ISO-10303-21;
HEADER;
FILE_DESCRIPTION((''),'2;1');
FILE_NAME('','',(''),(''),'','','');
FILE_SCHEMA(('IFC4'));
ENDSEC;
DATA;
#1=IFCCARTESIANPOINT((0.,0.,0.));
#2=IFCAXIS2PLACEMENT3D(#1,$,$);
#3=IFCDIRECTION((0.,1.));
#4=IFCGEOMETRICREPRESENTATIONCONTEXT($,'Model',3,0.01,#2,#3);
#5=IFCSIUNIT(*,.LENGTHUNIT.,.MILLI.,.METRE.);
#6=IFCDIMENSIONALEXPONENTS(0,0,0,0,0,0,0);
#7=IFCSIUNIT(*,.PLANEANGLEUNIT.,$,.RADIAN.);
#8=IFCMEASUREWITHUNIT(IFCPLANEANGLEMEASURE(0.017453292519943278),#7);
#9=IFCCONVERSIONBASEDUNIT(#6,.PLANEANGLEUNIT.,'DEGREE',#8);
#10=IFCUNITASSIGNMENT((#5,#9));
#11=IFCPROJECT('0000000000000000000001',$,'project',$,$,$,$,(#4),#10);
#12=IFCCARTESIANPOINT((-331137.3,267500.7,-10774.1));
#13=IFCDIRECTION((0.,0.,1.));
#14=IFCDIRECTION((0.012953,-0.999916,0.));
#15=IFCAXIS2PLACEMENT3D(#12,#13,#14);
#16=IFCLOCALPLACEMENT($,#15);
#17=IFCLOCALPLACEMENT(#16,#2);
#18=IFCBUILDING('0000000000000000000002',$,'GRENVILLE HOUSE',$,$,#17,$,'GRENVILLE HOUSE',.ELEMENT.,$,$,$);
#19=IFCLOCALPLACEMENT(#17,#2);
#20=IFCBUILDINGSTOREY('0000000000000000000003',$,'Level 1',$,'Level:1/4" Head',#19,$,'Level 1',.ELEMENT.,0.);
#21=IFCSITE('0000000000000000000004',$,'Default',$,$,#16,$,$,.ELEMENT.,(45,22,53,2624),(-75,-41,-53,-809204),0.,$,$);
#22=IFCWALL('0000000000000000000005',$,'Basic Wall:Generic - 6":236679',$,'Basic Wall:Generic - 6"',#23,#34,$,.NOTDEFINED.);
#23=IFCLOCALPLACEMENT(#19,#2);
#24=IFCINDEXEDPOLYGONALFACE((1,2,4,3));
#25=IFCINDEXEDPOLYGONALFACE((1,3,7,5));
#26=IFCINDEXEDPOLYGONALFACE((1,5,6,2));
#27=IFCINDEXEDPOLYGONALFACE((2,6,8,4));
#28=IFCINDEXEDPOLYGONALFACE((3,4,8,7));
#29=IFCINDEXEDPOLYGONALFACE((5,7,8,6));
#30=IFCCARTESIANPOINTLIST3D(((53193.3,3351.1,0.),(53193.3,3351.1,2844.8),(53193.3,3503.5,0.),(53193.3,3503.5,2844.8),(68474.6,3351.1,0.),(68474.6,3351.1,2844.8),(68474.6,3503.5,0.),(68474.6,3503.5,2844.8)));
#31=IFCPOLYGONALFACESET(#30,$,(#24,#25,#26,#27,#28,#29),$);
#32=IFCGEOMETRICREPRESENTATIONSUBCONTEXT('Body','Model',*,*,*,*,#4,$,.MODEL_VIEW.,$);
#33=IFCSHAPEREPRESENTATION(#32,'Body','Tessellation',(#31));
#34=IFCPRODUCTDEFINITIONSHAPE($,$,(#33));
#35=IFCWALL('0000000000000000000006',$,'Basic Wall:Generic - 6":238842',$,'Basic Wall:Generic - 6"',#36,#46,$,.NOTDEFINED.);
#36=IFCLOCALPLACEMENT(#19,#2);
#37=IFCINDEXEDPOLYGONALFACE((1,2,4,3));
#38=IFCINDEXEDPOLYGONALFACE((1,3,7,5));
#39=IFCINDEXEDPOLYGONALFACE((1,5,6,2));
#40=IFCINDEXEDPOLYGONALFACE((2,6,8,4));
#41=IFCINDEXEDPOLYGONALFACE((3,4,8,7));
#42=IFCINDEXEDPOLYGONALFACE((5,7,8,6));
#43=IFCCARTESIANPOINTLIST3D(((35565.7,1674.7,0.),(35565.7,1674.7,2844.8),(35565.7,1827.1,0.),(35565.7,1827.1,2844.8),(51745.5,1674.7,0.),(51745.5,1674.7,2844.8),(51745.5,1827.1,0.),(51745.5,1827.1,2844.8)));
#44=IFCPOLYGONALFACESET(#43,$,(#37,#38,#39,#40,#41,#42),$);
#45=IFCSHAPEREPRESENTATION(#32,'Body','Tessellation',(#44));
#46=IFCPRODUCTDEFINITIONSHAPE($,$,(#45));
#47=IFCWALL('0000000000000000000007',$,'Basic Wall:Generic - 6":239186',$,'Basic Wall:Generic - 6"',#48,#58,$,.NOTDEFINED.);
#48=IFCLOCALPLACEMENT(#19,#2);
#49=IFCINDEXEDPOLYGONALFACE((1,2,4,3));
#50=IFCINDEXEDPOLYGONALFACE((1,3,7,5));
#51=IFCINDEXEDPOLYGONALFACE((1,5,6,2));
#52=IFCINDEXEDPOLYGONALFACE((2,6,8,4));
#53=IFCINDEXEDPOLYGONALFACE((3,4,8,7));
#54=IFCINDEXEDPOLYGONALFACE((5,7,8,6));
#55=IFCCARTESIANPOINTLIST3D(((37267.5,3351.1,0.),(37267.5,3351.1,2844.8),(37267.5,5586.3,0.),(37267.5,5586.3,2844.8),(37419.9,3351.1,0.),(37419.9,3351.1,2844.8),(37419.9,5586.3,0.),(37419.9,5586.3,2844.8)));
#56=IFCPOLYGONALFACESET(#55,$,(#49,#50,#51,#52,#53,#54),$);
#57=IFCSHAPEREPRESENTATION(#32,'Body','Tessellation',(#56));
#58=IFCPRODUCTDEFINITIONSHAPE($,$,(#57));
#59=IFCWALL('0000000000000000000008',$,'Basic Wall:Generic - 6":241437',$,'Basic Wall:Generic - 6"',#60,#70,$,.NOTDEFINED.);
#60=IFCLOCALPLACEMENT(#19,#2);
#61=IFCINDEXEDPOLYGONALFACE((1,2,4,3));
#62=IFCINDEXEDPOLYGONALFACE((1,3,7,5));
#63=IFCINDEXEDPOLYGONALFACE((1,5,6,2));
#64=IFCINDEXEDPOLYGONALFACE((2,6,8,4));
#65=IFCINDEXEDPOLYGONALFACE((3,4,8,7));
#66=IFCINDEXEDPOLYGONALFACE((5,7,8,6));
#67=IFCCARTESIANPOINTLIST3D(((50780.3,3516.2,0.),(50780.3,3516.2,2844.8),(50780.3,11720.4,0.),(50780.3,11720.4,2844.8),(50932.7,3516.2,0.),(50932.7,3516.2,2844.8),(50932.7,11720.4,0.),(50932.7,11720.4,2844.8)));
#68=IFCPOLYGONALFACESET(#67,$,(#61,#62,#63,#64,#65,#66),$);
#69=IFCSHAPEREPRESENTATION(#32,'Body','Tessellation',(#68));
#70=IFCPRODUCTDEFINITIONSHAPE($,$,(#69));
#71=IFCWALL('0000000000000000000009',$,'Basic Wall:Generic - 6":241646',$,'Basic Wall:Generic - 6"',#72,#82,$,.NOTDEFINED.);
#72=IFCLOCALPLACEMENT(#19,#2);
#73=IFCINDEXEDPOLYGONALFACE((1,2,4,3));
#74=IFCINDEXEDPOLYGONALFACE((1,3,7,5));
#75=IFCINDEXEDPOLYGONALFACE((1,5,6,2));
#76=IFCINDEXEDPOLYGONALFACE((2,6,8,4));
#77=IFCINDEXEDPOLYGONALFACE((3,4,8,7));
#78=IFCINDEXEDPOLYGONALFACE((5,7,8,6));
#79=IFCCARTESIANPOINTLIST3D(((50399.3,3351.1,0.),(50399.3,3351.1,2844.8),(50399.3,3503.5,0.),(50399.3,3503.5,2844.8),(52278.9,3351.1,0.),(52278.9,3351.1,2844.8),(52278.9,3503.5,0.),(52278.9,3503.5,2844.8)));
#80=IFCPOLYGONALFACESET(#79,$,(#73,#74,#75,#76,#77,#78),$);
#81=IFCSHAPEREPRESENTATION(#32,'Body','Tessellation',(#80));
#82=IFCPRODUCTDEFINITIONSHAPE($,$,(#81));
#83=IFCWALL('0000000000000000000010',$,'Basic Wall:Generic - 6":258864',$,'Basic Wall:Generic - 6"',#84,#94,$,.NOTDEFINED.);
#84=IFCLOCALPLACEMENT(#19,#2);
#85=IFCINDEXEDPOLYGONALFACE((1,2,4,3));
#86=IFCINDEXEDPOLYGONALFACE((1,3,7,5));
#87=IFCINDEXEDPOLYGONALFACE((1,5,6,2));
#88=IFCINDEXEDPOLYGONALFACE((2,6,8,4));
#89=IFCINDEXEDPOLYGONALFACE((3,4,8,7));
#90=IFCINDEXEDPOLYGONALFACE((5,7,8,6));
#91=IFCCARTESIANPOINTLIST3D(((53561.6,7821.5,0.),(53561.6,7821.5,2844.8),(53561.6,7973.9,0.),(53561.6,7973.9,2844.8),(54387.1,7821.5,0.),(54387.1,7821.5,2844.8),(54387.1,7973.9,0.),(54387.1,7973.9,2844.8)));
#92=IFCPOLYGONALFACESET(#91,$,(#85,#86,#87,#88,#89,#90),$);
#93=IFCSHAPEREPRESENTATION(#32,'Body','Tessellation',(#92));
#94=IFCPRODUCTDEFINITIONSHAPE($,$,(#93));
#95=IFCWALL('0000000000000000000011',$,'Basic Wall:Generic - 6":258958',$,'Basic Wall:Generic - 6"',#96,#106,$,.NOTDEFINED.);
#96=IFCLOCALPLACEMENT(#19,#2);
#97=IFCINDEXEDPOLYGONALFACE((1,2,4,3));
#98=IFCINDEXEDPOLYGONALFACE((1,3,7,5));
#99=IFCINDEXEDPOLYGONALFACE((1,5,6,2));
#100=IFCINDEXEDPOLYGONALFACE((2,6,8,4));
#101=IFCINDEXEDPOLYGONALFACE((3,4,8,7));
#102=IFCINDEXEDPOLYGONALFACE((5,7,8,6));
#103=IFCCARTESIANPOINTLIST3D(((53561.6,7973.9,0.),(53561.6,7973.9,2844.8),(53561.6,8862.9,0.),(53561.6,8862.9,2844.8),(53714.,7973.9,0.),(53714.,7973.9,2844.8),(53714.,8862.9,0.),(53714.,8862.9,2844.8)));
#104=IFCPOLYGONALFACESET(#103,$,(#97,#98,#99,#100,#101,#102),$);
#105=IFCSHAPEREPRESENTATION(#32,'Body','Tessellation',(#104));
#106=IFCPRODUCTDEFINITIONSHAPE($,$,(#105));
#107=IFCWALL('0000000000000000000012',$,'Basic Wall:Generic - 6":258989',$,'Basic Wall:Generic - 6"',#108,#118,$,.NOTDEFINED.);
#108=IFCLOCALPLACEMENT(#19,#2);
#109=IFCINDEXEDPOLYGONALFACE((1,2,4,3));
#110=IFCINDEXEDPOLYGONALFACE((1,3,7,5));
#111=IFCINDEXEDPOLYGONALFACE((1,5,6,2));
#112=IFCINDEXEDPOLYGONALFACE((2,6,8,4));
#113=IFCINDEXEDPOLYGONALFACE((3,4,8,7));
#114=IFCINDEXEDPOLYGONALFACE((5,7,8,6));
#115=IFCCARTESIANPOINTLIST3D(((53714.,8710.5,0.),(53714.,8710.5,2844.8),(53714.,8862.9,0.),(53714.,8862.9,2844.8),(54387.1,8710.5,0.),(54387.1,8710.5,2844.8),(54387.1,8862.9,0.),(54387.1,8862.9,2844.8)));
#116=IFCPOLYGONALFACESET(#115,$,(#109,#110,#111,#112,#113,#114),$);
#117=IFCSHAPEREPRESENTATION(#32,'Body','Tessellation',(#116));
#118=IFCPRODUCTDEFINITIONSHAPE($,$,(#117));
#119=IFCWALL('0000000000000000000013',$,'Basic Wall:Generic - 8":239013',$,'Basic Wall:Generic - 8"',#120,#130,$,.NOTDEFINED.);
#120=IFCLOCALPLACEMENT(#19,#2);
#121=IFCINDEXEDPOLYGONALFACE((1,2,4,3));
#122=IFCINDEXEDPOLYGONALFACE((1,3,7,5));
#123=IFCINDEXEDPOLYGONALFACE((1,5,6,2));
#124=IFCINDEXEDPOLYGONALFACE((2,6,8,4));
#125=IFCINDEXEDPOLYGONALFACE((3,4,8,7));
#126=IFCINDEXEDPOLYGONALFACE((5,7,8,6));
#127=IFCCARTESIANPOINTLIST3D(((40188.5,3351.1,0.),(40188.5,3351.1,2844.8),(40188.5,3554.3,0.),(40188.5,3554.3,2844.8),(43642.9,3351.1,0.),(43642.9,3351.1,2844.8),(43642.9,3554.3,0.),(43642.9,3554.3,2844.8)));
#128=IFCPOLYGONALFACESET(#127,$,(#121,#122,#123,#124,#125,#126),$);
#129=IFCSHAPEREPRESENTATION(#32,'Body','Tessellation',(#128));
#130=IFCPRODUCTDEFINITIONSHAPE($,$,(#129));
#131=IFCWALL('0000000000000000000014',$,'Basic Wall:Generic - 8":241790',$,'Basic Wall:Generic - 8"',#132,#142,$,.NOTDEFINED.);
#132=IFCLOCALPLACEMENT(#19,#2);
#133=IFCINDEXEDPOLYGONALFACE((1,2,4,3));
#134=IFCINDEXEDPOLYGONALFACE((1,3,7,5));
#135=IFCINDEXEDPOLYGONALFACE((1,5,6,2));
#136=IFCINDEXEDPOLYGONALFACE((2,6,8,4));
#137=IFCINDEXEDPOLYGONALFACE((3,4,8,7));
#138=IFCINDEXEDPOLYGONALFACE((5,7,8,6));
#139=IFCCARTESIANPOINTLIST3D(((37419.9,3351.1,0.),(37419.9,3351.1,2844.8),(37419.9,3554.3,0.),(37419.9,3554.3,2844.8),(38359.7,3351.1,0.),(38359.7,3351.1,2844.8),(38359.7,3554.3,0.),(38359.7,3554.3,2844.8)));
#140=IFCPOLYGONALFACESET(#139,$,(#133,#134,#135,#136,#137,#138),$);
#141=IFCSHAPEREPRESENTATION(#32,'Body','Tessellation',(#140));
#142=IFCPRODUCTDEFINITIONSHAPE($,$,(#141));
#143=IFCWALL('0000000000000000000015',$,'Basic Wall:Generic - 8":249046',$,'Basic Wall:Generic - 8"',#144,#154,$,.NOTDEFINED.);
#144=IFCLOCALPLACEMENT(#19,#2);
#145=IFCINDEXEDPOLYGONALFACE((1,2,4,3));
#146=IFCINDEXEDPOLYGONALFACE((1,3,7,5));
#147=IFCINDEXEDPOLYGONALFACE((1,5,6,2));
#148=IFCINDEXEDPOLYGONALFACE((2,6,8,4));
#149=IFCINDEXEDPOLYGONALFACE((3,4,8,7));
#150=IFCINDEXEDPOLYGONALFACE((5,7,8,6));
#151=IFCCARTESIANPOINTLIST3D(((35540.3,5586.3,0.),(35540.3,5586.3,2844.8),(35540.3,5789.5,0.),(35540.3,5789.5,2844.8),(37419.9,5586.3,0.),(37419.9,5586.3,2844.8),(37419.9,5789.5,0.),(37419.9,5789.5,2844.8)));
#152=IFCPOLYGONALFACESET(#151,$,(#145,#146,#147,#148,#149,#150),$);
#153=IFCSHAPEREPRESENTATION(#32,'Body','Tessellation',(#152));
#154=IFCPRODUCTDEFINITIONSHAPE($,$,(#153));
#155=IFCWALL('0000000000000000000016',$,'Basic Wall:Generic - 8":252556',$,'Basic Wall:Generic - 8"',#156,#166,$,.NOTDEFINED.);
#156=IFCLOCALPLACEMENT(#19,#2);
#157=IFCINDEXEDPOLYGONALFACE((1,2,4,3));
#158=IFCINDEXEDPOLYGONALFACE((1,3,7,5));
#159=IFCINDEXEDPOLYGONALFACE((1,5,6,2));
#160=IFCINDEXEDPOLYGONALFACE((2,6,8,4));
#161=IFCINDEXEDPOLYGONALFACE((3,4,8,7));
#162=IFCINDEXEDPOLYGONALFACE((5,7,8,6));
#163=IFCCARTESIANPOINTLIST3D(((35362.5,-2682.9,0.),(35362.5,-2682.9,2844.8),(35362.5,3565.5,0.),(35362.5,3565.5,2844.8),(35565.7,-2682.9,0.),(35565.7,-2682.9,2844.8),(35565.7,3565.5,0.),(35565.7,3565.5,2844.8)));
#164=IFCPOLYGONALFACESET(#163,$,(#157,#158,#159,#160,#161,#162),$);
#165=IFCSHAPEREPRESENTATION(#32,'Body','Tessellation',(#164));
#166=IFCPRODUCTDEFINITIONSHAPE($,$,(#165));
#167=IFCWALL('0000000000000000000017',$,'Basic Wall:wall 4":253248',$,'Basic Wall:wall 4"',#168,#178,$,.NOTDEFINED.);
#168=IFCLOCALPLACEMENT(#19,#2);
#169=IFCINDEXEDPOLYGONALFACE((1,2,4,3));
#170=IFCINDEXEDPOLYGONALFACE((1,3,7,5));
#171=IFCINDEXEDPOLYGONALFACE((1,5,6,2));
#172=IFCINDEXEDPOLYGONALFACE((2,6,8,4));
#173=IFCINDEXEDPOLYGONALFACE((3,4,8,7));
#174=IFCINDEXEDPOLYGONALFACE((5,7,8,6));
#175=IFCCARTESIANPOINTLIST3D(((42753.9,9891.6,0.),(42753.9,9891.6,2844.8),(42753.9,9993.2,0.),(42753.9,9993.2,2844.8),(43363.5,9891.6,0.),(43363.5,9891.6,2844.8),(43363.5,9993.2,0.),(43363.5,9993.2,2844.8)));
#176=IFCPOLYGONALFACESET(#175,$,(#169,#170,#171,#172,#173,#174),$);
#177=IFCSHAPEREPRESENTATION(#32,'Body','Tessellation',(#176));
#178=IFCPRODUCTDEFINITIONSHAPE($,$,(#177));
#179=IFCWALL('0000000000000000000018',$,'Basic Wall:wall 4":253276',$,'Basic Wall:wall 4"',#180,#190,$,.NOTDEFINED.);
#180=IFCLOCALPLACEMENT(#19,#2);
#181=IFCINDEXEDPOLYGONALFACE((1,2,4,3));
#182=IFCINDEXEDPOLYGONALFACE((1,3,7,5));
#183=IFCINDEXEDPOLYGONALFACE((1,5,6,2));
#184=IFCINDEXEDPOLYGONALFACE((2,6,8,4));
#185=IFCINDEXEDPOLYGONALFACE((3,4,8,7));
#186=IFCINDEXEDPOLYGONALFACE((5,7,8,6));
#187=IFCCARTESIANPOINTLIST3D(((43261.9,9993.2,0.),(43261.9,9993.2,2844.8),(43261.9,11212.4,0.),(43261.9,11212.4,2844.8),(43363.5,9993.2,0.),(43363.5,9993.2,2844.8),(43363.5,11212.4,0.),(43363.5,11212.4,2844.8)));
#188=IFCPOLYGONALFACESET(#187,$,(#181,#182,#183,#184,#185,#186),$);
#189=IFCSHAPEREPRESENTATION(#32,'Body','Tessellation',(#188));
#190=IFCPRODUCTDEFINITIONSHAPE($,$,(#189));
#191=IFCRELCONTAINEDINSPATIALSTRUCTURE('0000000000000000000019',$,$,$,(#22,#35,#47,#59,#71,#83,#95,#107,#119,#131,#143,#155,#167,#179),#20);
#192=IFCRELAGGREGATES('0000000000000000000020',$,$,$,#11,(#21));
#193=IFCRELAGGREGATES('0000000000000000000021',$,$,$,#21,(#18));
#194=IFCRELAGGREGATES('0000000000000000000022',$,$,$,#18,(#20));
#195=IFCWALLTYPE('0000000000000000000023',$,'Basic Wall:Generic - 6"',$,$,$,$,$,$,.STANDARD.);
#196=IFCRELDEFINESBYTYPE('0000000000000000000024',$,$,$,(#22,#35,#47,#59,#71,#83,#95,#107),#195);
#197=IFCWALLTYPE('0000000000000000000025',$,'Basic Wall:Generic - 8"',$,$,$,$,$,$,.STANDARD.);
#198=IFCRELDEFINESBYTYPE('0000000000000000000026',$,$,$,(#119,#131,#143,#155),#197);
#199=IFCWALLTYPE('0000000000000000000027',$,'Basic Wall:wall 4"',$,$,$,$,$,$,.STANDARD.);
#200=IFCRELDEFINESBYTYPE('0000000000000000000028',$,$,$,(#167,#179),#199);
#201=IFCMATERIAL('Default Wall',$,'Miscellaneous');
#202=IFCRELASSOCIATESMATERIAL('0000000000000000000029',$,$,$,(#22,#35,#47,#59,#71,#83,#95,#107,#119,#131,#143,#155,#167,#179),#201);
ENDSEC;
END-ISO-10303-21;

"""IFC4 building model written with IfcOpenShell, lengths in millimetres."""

from ifc_helpers import new_model, entity, si_unit, converted_unit, direction, frame, origin, place, context, subcontext, project, spatial, indexed_curve, outline, extrude, material, type_object, element, save


model = new_model("IFC4")

# Units and contexts
model_context = context("Model", 3, precision=0.01, world=origin(), true_north=direction((0.0, 1.0)))
body_context = subcontext(model_context, "Body", "Model", "MODEL_VIEW")
ifc_project = project(units=[si_unit("LENGTHUNIT", "METRE", prefix="MILLI"), converted_unit("PLANEANGLEUNIT", "DEGREE", entity("IfcPlaneAngleMeasure", 0.017453292519943278), si_unit("PLANEANGLEUNIT", "RADIAN"), dimensions=[0, 0, 0, 0, 0, 0, 0])], contexts=[model_context])

# Site, building, storey
site_placement = place(None, frame((-331137.3, 267500.7, -10774.1), z_axis=(0.0, 0.0, 1.0), x_axis=(0.012953, -0.999916, 0.0)))
site = spatial("IfcSite", under=ifc_project, at=site_placement, Name="Default", CompositionType="ELEMENT", RefLatitude=(45, 22, 53, 2624), RefLongitude=(-75, -41, -53, -809204), RefElevation=0.0)
building_placement = place(site_placement, origin())
building = spatial("IfcBuilding", under=site, at=building_placement, Name="GRENVILLE HOUSE", LongName="GRENVILLE HOUSE", CompositionType="ELEMENT")
storey_placement = place(building_placement, origin())
storey = spatial("IfcBuildingStorey", under=building, at=storey_placement, Name="Level 1", ObjectType="Level:1/4\" Head", LongName="Level 1", CompositionType="ELEMENT", Elevation=0.0)

# Walls
ifc_material_1 = material(Name="Default Wall", Category="Miscellaneous")
wall_type_1 = type_object("IfcWallType", Name="Basic Wall:Generic - 6\"", PredefinedType="STANDARD")
wall_1_placement = place(storey_placement, frame((53193.3, 3427.3, 0.0)))
element("IfcWall", 1, at=wall_1_placement, inside=storey, type_object=wall_type_1, material=ifc_material_1, Name="Basic Wall:Generic - 6\":236679", ObjectType="Basic Wall:Generic - 6\"", PredefinedType="NOTDEFINED", context=body_context, shape_type="SweptSolid", body=[
    extrude(outline(indexed_curve([(15281.3, 76.2), (0.0, 76.2), (0.0, -76.2), (15281.3, -76.2), (15281.3, 76.2)], self_intersect=False)), origin(), (0.0, 0.0, 1.0), 2844.8),
])
wall_2_placement = place(storey_placement, frame((51745.5, 1750.9, 0.0), z_axis=(0.0, 0.0, 1.0), x_axis=(-1.0, 0.0, 0.0)))
element("IfcWall", 2, at=wall_2_placement, inside=storey, type_object=wall_type_1, material=ifc_material_1, Name="Basic Wall:Generic - 6\":238842", ObjectType="Basic Wall:Generic - 6\"", PredefinedType="NOTDEFINED", context=body_context, shape_type="SweptSolid", body=[
    extrude(outline(indexed_curve([(16179.8, 76.2), (0.0, 76.2), (0.0, -76.2), (16179.8, -76.2), (16179.8, 76.2)], self_intersect=False)), origin(), (0.0, 0.0, 1.0), 2844.8),
])
wall_3_placement = place(storey_placement, frame((37343.7, 3351.1, 0.0), z_axis=(0.0, 0.0, 1.0), x_axis=(0.0, 1.0, 0.0)))
element("IfcWall", 3, at=wall_3_placement, inside=storey, type_object=wall_type_1, material=ifc_material_1, Name="Basic Wall:Generic - 6\":239186", ObjectType="Basic Wall:Generic - 6\"", PredefinedType="NOTDEFINED", context=body_context, shape_type="SweptSolid", body=[
    extrude(outline(indexed_curve([(2235.2, 76.2), (0.0, 76.2), (0.0, -76.2), (2235.2, -76.2), (2235.2, 76.2)], self_intersect=False)), origin(), (0.0, 0.0, 1.0), 2844.8),
])
wall_4_placement = place(storey_placement, frame((50856.5, 3516.2, 0.0), z_axis=(0.0, 0.0, 1.0), x_axis=(0.0, 1.0, 0.0)))
element("IfcWall", 4, at=wall_4_placement, inside=storey, type_object=wall_type_1, material=ifc_material_1, Name="Basic Wall:Generic - 6\":241437", ObjectType="Basic Wall:Generic - 6\"", PredefinedType="NOTDEFINED", context=body_context, shape_type="SweptSolid", body=[
    extrude(outline(indexed_curve([(8204.2, 76.2), (0.0, 76.2), (0.0, -76.2), (8204.2, -76.2), (8204.2, 76.2)], self_intersect=False)), origin(), (0.0, 0.0, 1.0), 2844.8),
])
wall_5_placement = place(storey_placement, frame((52278.9, 3427.3, 0.0), z_axis=(0.0, 0.0, 1.0), x_axis=(-1.0, 0.0, 0.0)))
element("IfcWall", 5, at=wall_5_placement, inside=storey, type_object=wall_type_1, material=ifc_material_1, Name="Basic Wall:Generic - 6\":241646", ObjectType="Basic Wall:Generic - 6\"", PredefinedType="NOTDEFINED", context=body_context, shape_type="SweptSolid", body=[
    extrude(outline(indexed_curve([(1879.6, 76.2), (0.0, 76.2), (0.0, -76.2), (1879.6, -76.2), (1879.6, 76.2)], self_intersect=False)), origin(), (0.0, 0.0, 1.0), 2844.8),
])
wall_6_placement = place(storey_placement, frame((53561.6, 7897.7, 0.0)))
element("IfcWall", 6, at=wall_6_placement, inside=storey, type_object=wall_type_1, material=ifc_material_1, Name="Basic Wall:Generic - 6\":258864", ObjectType="Basic Wall:Generic - 6\"", PredefinedType="NOTDEFINED", context=body_context, shape_type="SweptSolid", body=[
    extrude(outline(indexed_curve([(825.5, 76.2), (0.0, 76.2), (0.0, -76.2), (825.5, -76.2), (825.5, 76.2)], self_intersect=False)), origin(), (0.0, 0.0, 1.0), 2844.8),
])
wall_7_placement = place(storey_placement, frame((53637.8, 7973.9, 0.0), z_axis=(0.0, 0.0, 1.0), x_axis=(0.0, 1.0, 0.0)))
element("IfcWall", 7, at=wall_7_placement, inside=storey, type_object=wall_type_1, material=ifc_material_1, Name="Basic Wall:Generic - 6\":258958", ObjectType="Basic Wall:Generic - 6\"", PredefinedType="NOTDEFINED", context=body_context, shape_type="SweptSolid", body=[
    extrude(outline(indexed_curve([(889.0, 76.2), (0.0, 76.2), (0.0, -76.2), (889.0, -76.2), (889.0, 76.2)], self_intersect=False)), origin(), (0.0, 0.0, 1.0), 2844.8),
])
wall_8_placement = place(storey_placement, frame((53714.0, 8786.7, 0.0)))
element("IfcWall", 8, at=wall_8_placement, inside=storey, type_object=wall_type_1, material=ifc_material_1, Name="Basic Wall:Generic - 6\":258989", ObjectType="Basic Wall:Generic - 6\"", PredefinedType="NOTDEFINED", context=body_context, shape_type="SweptSolid", body=[
    extrude(outline(indexed_curve([(673.1, 76.2), (0.0, 76.2), (0.0, -76.2), (673.1, -76.2), (673.1, 76.2)], self_intersect=False)), origin(), (0.0, 0.0, 1.0), 2844.8),
])
wall_type_2 = type_object("IfcWallType", Name="Basic Wall:Generic - 8\"", PredefinedType="STANDARD")
wall_9_placement = place(storey_placement, frame((43642.9, 3452.7, 0.0), z_axis=(0.0, 0.0, 1.0), x_axis=(-1.0, 0.0, 0.0)))
element("IfcWall", 9, at=wall_9_placement, inside=storey, type_object=wall_type_2, material=ifc_material_1, Name="Basic Wall:Generic - 8\":239013", ObjectType="Basic Wall:Generic - 8\"", PredefinedType="NOTDEFINED", context=body_context, shape_type="SweptSolid", body=[
    extrude(outline(indexed_curve([(3454.4, 101.6), (0.0, 101.6), (0.0, -101.6), (3454.4, -101.6), (3454.4, 101.6)], self_intersect=False)), origin(), (0.0, 0.0, 1.0), 2844.8),
])
wall_10_placement = place(storey_placement, frame((37419.9, 3452.7, 0.0)))
element("IfcWall", 10, at=wall_10_placement, inside=storey, type_object=wall_type_2, material=ifc_material_1, Name="Basic Wall:Generic - 8\":241790", ObjectType="Basic Wall:Generic - 8\"", PredefinedType="NOTDEFINED", context=body_context, shape_type="SweptSolid", body=[
    extrude(outline(indexed_curve([(939.8, 101.6), (0.0, 101.6), (0.0, -101.6), (939.8, -101.6), (939.8, 101.6)], self_intersect=False)), origin(), (0.0, 0.0, 1.0), 2844.8),
])
wall_11_placement = place(storey_placement, frame((37419.9, 5687.9, 0.0), z_axis=(0.0, 0.0, 1.0), x_axis=(-1.0, 0.0, 0.0)))
element("IfcWall", 11, at=wall_11_placement, inside=storey, type_object=wall_type_2, material=ifc_material_1, Name="Basic Wall:Generic - 8\":249046", ObjectType="Basic Wall:Generic - 8\"", PredefinedType="NOTDEFINED", context=body_context, shape_type="SweptSolid", body=[
    extrude(outline(indexed_curve([(1879.6, 101.6), (0.0, 101.6), (0.0, -101.6), (1879.6, -101.6), (1879.6, 101.6)], self_intersect=False)), origin(), (0.0, 0.0, 1.0), 2844.8),
])
wall_12_placement = place(storey_placement, frame((35464.1, -2682.9, 0.0), z_axis=(0.0, 0.0, 1.0), x_axis=(0.0, 1.0, 0.0)))
element("IfcWall", 12, at=wall_12_placement, inside=storey, type_object=wall_type_2, material=ifc_material_1, Name="Basic Wall:Generic - 8\":252556", ObjectType="Basic Wall:Generic - 8\"", PredefinedType="NOTDEFINED", context=body_context, shape_type="SweptSolid", body=[
    extrude(outline(indexed_curve([(6248.4, 101.6), (0.0, 101.6), (0.0, -101.6), (6248.4, -101.6), (6248.4, 101.6)], self_intersect=False)), origin(), (0.0, 0.0, 1.0), 2844.8),
])
wall_type_3 = type_object("IfcWallType", Name="Basic Wall:wall 4\"", PredefinedType="STANDARD")
wall_13_placement = place(storey_placement, frame((42753.9, 9942.4, 0.0)))
element("IfcWall", 13, at=wall_13_placement, inside=storey, type_object=wall_type_3, material=ifc_material_1, Name="Basic Wall:wall 4\":253248", ObjectType="Basic Wall:wall 4\"", PredefinedType="NOTDEFINED", context=body_context, shape_type="SweptSolid", body=[
    extrude(outline(indexed_curve([(609.6, 50.8), (0.0, 50.8), (0.0, -50.8), (609.6, -50.8), (609.6, 50.8)], self_intersect=False)), origin(), (0.0, 0.0, 1.0), 2844.8),
])
wall_14_placement = place(storey_placement, frame((43312.7, 9993.2, 0.0), z_axis=(0.0, 0.0, 1.0), x_axis=(0.0, 1.0, 0.0)))
element("IfcWall", 14, at=wall_14_placement, inside=storey, type_object=wall_type_3, material=ifc_material_1, Name="Basic Wall:wall 4\":253276", ObjectType="Basic Wall:wall 4\"", PredefinedType="NOTDEFINED", context=body_context, shape_type="SweptSolid", body=[
    extrude(outline(indexed_curve([(1219.2, 50.8), (0.0, 50.8), (0.0, -50.8), (1219.2, -50.8), (1219.2, 50.8)], self_intersect=False)), origin(), (0.0, 0.0, 1.0), 2844.8),
])

save(model, "model.ifc")
